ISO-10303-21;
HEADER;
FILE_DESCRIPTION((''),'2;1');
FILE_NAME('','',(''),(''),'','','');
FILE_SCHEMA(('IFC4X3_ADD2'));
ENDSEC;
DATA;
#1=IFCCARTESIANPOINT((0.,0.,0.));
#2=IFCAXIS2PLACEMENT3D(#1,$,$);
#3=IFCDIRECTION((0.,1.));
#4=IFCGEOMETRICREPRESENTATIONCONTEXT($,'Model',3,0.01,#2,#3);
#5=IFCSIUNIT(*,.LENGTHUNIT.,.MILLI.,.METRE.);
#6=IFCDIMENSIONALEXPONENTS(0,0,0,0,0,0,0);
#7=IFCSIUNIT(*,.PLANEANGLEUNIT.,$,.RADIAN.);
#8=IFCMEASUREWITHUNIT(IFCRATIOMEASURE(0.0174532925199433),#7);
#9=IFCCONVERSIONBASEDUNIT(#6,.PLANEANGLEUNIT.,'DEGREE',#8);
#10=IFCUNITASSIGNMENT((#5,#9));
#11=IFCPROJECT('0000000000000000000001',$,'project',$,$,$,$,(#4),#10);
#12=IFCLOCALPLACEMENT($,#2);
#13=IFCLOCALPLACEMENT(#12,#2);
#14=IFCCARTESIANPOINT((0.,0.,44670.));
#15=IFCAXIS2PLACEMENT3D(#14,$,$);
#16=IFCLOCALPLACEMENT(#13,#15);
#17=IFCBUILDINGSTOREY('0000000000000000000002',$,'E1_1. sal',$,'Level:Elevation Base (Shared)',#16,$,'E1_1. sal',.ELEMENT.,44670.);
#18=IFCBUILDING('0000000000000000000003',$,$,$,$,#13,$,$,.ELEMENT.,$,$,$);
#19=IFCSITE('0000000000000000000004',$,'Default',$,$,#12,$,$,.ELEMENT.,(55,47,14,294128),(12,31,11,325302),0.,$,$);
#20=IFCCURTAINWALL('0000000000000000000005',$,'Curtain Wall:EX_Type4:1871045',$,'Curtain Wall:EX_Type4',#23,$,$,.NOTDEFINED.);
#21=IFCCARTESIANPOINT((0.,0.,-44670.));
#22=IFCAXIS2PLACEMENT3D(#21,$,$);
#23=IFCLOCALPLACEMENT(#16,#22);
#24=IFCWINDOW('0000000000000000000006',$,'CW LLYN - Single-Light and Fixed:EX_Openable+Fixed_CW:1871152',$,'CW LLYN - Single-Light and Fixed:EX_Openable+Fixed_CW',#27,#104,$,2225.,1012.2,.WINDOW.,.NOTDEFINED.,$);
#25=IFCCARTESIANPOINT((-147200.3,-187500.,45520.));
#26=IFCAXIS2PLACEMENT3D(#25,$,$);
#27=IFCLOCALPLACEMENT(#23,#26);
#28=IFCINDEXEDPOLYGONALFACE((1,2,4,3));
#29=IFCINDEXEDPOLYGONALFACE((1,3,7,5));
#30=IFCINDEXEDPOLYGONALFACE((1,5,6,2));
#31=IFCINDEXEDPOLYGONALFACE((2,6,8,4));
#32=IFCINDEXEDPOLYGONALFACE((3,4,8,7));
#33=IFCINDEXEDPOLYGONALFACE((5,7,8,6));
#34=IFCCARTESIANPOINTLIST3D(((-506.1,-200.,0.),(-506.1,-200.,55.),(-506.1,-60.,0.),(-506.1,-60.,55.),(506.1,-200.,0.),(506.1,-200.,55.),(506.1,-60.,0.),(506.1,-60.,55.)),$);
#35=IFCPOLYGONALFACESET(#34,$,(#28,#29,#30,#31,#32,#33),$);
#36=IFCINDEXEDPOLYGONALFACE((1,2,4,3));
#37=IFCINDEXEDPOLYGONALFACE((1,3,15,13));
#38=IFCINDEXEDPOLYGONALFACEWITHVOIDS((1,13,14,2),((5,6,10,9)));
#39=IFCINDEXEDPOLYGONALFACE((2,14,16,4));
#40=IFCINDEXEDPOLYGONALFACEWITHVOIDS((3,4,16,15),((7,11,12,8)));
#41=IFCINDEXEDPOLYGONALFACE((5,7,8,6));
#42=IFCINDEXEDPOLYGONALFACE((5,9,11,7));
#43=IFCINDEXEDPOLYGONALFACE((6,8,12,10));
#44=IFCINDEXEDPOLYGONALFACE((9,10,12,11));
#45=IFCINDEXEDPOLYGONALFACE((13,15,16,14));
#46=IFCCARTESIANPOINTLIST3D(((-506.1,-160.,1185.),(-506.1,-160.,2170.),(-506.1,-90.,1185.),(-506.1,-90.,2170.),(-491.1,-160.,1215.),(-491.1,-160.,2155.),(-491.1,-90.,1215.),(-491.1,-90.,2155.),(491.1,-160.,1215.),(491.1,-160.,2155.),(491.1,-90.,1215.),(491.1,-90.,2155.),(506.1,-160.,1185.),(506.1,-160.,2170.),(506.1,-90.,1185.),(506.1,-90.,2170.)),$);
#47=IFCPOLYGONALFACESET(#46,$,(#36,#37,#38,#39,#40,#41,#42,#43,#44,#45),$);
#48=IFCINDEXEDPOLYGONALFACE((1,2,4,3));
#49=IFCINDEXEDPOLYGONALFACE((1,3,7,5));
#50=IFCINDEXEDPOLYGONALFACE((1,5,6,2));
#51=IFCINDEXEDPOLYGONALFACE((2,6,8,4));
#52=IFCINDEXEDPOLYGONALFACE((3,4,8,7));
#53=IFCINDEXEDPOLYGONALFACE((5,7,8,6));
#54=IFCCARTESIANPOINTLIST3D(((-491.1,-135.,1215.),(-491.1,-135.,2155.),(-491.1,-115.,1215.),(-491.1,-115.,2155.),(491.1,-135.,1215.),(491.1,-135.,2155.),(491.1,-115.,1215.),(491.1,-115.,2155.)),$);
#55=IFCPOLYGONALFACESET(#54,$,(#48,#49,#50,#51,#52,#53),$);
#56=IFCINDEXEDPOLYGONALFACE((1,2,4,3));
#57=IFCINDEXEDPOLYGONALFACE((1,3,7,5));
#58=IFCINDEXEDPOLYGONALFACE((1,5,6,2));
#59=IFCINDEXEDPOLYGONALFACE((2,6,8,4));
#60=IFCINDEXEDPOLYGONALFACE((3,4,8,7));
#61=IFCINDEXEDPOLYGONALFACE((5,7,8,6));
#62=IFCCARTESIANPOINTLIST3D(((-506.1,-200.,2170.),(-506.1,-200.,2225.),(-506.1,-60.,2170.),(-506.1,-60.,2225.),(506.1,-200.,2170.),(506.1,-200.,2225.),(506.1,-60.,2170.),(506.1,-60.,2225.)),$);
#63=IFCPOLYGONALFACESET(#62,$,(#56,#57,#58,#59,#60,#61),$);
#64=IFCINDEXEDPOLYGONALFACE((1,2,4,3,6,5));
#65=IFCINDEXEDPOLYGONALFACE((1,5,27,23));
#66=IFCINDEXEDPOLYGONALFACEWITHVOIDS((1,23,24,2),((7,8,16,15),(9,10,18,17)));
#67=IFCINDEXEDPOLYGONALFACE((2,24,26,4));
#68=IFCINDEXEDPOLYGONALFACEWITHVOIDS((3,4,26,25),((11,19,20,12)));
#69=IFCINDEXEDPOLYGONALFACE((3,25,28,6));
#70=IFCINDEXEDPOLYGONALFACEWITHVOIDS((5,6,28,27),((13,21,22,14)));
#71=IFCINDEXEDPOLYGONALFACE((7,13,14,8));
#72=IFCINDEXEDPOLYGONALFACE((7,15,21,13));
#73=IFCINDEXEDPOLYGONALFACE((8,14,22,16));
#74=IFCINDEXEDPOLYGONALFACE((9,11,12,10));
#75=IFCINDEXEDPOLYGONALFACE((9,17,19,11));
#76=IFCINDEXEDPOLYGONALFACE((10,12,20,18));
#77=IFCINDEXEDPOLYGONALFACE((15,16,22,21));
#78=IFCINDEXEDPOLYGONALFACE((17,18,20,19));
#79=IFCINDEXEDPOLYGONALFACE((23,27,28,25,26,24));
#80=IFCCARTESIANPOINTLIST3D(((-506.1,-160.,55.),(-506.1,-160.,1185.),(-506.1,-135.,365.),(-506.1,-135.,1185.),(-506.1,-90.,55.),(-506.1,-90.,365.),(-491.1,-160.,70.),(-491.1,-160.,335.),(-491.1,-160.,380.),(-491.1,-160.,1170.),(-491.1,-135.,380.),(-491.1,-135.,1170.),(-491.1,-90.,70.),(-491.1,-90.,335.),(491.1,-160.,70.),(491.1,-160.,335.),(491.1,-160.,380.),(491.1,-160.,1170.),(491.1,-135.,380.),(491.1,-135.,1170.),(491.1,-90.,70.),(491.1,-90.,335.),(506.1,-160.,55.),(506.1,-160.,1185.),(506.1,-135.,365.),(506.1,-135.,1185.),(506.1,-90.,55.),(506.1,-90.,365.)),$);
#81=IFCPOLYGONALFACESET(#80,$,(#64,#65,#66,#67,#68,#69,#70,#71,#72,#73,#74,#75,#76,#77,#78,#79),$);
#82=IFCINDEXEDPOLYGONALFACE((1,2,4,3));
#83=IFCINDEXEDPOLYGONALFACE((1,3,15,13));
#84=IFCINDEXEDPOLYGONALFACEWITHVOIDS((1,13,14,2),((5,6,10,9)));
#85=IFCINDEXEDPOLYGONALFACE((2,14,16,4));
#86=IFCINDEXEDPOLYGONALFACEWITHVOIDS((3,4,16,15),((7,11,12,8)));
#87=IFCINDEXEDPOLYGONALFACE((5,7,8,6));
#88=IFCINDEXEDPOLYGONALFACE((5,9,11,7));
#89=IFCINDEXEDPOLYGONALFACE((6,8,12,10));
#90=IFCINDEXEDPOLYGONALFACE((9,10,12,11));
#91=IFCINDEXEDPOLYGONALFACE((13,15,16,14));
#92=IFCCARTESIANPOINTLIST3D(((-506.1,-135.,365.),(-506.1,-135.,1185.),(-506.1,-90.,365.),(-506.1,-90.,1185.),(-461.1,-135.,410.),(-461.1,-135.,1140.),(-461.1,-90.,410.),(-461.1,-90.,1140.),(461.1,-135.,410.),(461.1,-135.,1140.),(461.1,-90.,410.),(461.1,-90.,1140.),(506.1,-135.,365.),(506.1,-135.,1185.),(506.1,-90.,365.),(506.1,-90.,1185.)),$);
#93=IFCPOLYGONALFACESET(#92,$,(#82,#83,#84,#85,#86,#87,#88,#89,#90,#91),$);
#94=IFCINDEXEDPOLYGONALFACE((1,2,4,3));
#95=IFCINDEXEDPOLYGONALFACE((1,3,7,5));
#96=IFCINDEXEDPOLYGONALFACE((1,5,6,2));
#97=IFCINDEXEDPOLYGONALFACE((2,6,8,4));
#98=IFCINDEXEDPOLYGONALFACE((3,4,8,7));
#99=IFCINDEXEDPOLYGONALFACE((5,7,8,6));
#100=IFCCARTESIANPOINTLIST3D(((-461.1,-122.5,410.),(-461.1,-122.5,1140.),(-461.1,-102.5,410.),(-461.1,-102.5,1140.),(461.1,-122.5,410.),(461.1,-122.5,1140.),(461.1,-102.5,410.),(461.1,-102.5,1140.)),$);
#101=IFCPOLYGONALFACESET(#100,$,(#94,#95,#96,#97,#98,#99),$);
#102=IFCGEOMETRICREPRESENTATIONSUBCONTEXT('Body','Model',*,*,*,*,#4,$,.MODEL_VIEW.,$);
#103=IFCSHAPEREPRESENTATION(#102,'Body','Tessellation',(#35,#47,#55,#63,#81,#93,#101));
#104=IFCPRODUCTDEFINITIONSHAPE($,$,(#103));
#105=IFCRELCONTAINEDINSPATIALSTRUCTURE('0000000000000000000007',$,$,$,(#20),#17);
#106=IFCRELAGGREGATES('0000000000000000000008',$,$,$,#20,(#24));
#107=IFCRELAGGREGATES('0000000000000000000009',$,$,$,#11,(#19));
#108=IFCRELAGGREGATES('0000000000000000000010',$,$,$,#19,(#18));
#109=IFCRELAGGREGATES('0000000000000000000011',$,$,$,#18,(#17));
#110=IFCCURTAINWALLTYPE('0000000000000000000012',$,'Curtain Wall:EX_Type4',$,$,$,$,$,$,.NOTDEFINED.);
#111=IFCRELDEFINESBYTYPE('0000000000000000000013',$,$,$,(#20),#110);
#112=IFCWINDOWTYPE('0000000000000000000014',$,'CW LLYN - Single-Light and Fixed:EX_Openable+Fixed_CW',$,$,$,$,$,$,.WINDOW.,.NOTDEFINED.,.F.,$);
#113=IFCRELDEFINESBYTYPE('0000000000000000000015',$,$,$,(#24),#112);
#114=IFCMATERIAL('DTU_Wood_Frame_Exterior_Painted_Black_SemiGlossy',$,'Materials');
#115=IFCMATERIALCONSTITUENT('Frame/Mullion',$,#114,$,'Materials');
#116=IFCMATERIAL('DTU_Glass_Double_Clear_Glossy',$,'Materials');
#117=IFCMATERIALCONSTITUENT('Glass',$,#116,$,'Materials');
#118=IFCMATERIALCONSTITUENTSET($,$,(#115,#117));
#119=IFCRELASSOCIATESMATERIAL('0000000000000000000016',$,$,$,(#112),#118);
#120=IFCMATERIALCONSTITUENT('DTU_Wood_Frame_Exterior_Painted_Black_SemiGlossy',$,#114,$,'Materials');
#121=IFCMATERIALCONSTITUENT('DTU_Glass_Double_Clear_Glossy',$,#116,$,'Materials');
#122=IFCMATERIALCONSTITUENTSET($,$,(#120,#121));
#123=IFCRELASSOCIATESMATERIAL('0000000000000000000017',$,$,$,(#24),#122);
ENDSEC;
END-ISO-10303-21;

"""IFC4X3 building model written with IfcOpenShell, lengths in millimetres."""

from ifc_helpers import new_model, entity, si_unit, converted_unit, direction, frame, frame_2d, origin, origin_2d_with_axis, place, context, subcontext, project, spatial, polyline, rectangle, outline, extrude, source, transform, mapped, material, constituent, constituent_set, type_object, type_shapes, element, aggregate, save


model = new_model("IFC4X3")

# Units and contexts
model_context = context("Model", 3, precision=0.01, world=origin(), true_north=direction((0.0, 1.0)))
body_context = subcontext(model_context, "Body", "Model", "MODEL_VIEW")
ifc_project = project(units=[si_unit("LENGTHUNIT", "METRE", prefix="MILLI"), converted_unit("PLANEANGLEUNIT", "DEGREE", entity("IfcRatioMeasure", 0.0174532925199433), si_unit("PLANEANGLEUNIT", "RADIAN"), dimensions=[0, 0, 0, 0, 0, 0, 0])], contexts=[model_context])

# Site, building, storey
site_placement = place(None, origin())
site = spatial("IfcSite", under=ifc_project, at=site_placement, Name="Default", CompositionType="ELEMENT", RefLatitude=(55, 47, 14, 294128), RefLongitude=(12, 31, 11, 325302), RefElevation=0.0)
building_placement = place(site_placement, origin())
building = spatial("IfcBuilding", under=site, at=building_placement, CompositionType="ELEMENT")
storey_placement = place(building_placement, frame((0.0, 0.0, 44670.0)))
storey = spatial("IfcBuildingStorey", under=building, at=storey_placement, Name="E1_1. sal", ObjectType="Level:Elevation Base (Shared)", LongName="E1_1. sal", CompositionType="ELEMENT", Elevation=44670.0)

# Curtain wall, window, openings
curtain_wall_type = type_object("IfcCurtainWallType", Name="Curtain Wall:EX_Type4", PredefinedType="NOTDEFINED")
curtain_wall_placement = place(storey_placement, frame((0.0, 0.0, -44670.0)))
curtain_wall = element("IfcCurtainWall", 1, at=curtain_wall_placement, inside=storey, type_object=curtain_wall_type, Name="Curtain Wall:EX_Type4:1871045", ObjectType="Curtain Wall:EX_Type4", PredefinedType="NOTDEFINED")
ifc_material_1 = material(Name="DTU_Wood_Frame_Exterior_Painted_Black_SemiGlossy", Category="Materials")
ifc_material_2 = material(Name="DTU_Glass_Double_Clear_Glossy", Category="Materials")
ifc_constituent_1 = constituent(ifc_material_1, Name="DTU_Wood_Frame_Exterior_Painted_Black_SemiGlossy", Category="Materials")
ifc_constituent_2 = constituent(ifc_material_2, Name="DTU_Glass_Double_Clear_Glossy", Category="Materials")
ifc_constituent_set_1 = constituent_set(constituents=[ifc_constituent_1, ifc_constituent_2])
ifc_constituent_3 = constituent(ifc_material_1, Name="Frame/Mullion", Category="Materials")
ifc_constituent_4 = constituent(ifc_material_2, Name="Glass", Category="Materials")
ifc_constituent_set_2 = constituent_set(constituents=[ifc_constituent_3, ifc_constituent_4])
window_type_1 = type_object("IfcWindowType", Name="CW LLYN - Single-Light and Fixed:EX_Openable+Fixed_CW", ParameterTakesPrecedence=False, PartitioningType="NOTDEFINED", PredefinedType="WINDOW", material=ifc_constituent_set_2)
shared_shape_1 = source(origin(), body_context, "Body", "SweptSolid", [
    extrude(rectangle(XDim=1012.2, YDim=140.0, at=origin_2d_with_axis()), frame((0.0, -130.0, 0.0), z_axis=(0.0, 0.0, 1.0), x_axis=(-1.0, 0.0, 0.0)), (0.0, 0.0, 1.0), 55.0),
    extrude(outline(polyline([(-492.5, -506.1), (492.5, -506.1), (492.5, 506.1), (-492.5, 506.1), (-492.5, -506.1)]), holes=[polyline([(477.5, -491.1), (-462.5, -491.1), (-462.5, 491.1), (477.5, 491.1), (477.5, -491.1)])]), frame((0.0, -160.0, 1677.5), z_axis=(0.0, 1.0, 0.0), x_axis=(0.0, 0.0, 1.0)), (0.0, 0.0, 1.0), 70.0),
    extrude(rectangle(XDim=20.0, YDim=982.2, at=frame_2d((0.0, 0.0), x_axis=(1.0, 0.0))), frame((0.0, -125.0, 1215.0), z_axis=(0.0, 0.0, 1.0), x_axis=(0.0, -1.0, 0.0)), (0.0, 0.0, 1.0), 940.0),
    extrude(rectangle(XDim=20.0, YDim=982.2, at=frame_2d((0.0, 0.0), x_axis=(1.0, 0.0))), frame((0.0, -125.0, 70.0), z_axis=(0.0, 0.0, 1.0), x_axis=(0.0, -1.0, 0.0)), (0.0, 0.0, 1.0), 265.0),
    extrude(rectangle(XDim=1012.2, YDim=140.0, at=origin_2d_with_axis()), frame((0.0, -130.0, 2170.0), z_axis=(0.0, 0.0, 1.0), x_axis=(-1.0, 0.0, 0.0)), (0.0, 0.0, 1.0), 55.0),
    extrude(outline(polyline([(-480.0, -38.3), (-170.0, -38.3), (-170.0, 6.7), (650.0, 6.7), (650.0, 31.7), (-480.0, 31.7), (-480.0, -38.3)])), frame((-506.1, -128.3, 535.0), z_axis=(1.0, 0.0, 0.0), x_axis=(0.0, 0.0, 1.0)), (0.0, 0.0, 1.0), 1012.2),
    extrude(outline(polyline([(-506.1, -410.0), (506.1, -410.0), (506.1, 410.0), (-506.1, 410.0), (-506.1, -410.0)]), holes=[polyline([(461.1, -365.0), (-461.1, -365.0), (-461.1, 365.0), (461.1, 365.0), (461.1, -365.0)])]), frame((0.0, -135.0, 775.0), z_axis=(0.0, 1.0, 0.0), x_axis=(-1.0, 0.0, 0.0)), (0.0, 0.0, 1.0), 45.0),
    extrude(rectangle(XDim=20.0, YDim=922.2, at=frame_2d((0.0, 0.0), x_axis=(1.0, 0.0))), frame((0.0, -112.5, 410.0), z_axis=(0.0, 0.0, 1.0), x_axis=(0.0, -1.0, 0.0)), (0.0, 0.0, 1.0), 730.0),
])
type_shapes(window_type_1, [shared_shape_1])
window_1_placement = place(curtain_wall_placement, frame((-147200.3, -187500.0, 45520.0)))
window_1 = element("IfcWindow", 2, at=window_1_placement, type_object=window_type_1, material=ifc_constituent_set_1, Name="CW LLYN - Single-Light and Fixed:EX_Openable+Fixed_CW:1871152", ObjectType="CW LLYN - Single-Light and Fixed:EX_Openable+Fixed_CW", OverallHeight=2225.0, OverallWidth=1012.2, PartitioningType="NOTDEFINED", PredefinedType="WINDOW", context=body_context, shape_type="MappedRepresentation", body=[
    mapped(shared_shape_1, transform((0.0, 0.0, 0.0), scale=1.0)),
])
opening_1_placement = place(curtain_wall_placement, frame((-147200.3, -187500.0, 90190.0)))
opening_1 = element("IfcOpeningElement", 3, at=opening_1_placement, cuts=window_1, PredefinedType="OPENING", context=body_context, shape_type="SweptSolid", body=[
    extrude(rectangle(XDim=265.0, YDim=982.2, at=frame_2d((0.0, 0.0), x_axis=(0.0, 1.0))), frame((0.0, -160.0, -44467.5), z_axis=(0.0, 1.0, 0.0), x_axis=(-1.0, 0.0, 0.0)), (0.0, 0.0, 1.0), 70.0),
])
opening_2_placement = place(curtain_wall_placement, frame((-147200.3, -187500.0, 90190.0)))
opening_2 = element("IfcOpeningElement", 4, at=opening_2_placement, cuts=window_1, PredefinedType="OPENING", context=body_context, shape_type="SweptSolid", body=[
    extrude(rectangle(XDim=790.0, YDim=982.2, at=frame_2d((0.0, 0.0), x_axis=(0.0, 1.0))), frame((0.0, -135.0, -43895.0), z_axis=(0.0, -1.0, 0.0), x_axis=(1.0, 0.0, 0.0)), (0.0, 0.0, 1.0), 25.0),
])
aggregate(curtain_wall, [window_1, opening_1, opening_2])

save(model, "model.ifc")
